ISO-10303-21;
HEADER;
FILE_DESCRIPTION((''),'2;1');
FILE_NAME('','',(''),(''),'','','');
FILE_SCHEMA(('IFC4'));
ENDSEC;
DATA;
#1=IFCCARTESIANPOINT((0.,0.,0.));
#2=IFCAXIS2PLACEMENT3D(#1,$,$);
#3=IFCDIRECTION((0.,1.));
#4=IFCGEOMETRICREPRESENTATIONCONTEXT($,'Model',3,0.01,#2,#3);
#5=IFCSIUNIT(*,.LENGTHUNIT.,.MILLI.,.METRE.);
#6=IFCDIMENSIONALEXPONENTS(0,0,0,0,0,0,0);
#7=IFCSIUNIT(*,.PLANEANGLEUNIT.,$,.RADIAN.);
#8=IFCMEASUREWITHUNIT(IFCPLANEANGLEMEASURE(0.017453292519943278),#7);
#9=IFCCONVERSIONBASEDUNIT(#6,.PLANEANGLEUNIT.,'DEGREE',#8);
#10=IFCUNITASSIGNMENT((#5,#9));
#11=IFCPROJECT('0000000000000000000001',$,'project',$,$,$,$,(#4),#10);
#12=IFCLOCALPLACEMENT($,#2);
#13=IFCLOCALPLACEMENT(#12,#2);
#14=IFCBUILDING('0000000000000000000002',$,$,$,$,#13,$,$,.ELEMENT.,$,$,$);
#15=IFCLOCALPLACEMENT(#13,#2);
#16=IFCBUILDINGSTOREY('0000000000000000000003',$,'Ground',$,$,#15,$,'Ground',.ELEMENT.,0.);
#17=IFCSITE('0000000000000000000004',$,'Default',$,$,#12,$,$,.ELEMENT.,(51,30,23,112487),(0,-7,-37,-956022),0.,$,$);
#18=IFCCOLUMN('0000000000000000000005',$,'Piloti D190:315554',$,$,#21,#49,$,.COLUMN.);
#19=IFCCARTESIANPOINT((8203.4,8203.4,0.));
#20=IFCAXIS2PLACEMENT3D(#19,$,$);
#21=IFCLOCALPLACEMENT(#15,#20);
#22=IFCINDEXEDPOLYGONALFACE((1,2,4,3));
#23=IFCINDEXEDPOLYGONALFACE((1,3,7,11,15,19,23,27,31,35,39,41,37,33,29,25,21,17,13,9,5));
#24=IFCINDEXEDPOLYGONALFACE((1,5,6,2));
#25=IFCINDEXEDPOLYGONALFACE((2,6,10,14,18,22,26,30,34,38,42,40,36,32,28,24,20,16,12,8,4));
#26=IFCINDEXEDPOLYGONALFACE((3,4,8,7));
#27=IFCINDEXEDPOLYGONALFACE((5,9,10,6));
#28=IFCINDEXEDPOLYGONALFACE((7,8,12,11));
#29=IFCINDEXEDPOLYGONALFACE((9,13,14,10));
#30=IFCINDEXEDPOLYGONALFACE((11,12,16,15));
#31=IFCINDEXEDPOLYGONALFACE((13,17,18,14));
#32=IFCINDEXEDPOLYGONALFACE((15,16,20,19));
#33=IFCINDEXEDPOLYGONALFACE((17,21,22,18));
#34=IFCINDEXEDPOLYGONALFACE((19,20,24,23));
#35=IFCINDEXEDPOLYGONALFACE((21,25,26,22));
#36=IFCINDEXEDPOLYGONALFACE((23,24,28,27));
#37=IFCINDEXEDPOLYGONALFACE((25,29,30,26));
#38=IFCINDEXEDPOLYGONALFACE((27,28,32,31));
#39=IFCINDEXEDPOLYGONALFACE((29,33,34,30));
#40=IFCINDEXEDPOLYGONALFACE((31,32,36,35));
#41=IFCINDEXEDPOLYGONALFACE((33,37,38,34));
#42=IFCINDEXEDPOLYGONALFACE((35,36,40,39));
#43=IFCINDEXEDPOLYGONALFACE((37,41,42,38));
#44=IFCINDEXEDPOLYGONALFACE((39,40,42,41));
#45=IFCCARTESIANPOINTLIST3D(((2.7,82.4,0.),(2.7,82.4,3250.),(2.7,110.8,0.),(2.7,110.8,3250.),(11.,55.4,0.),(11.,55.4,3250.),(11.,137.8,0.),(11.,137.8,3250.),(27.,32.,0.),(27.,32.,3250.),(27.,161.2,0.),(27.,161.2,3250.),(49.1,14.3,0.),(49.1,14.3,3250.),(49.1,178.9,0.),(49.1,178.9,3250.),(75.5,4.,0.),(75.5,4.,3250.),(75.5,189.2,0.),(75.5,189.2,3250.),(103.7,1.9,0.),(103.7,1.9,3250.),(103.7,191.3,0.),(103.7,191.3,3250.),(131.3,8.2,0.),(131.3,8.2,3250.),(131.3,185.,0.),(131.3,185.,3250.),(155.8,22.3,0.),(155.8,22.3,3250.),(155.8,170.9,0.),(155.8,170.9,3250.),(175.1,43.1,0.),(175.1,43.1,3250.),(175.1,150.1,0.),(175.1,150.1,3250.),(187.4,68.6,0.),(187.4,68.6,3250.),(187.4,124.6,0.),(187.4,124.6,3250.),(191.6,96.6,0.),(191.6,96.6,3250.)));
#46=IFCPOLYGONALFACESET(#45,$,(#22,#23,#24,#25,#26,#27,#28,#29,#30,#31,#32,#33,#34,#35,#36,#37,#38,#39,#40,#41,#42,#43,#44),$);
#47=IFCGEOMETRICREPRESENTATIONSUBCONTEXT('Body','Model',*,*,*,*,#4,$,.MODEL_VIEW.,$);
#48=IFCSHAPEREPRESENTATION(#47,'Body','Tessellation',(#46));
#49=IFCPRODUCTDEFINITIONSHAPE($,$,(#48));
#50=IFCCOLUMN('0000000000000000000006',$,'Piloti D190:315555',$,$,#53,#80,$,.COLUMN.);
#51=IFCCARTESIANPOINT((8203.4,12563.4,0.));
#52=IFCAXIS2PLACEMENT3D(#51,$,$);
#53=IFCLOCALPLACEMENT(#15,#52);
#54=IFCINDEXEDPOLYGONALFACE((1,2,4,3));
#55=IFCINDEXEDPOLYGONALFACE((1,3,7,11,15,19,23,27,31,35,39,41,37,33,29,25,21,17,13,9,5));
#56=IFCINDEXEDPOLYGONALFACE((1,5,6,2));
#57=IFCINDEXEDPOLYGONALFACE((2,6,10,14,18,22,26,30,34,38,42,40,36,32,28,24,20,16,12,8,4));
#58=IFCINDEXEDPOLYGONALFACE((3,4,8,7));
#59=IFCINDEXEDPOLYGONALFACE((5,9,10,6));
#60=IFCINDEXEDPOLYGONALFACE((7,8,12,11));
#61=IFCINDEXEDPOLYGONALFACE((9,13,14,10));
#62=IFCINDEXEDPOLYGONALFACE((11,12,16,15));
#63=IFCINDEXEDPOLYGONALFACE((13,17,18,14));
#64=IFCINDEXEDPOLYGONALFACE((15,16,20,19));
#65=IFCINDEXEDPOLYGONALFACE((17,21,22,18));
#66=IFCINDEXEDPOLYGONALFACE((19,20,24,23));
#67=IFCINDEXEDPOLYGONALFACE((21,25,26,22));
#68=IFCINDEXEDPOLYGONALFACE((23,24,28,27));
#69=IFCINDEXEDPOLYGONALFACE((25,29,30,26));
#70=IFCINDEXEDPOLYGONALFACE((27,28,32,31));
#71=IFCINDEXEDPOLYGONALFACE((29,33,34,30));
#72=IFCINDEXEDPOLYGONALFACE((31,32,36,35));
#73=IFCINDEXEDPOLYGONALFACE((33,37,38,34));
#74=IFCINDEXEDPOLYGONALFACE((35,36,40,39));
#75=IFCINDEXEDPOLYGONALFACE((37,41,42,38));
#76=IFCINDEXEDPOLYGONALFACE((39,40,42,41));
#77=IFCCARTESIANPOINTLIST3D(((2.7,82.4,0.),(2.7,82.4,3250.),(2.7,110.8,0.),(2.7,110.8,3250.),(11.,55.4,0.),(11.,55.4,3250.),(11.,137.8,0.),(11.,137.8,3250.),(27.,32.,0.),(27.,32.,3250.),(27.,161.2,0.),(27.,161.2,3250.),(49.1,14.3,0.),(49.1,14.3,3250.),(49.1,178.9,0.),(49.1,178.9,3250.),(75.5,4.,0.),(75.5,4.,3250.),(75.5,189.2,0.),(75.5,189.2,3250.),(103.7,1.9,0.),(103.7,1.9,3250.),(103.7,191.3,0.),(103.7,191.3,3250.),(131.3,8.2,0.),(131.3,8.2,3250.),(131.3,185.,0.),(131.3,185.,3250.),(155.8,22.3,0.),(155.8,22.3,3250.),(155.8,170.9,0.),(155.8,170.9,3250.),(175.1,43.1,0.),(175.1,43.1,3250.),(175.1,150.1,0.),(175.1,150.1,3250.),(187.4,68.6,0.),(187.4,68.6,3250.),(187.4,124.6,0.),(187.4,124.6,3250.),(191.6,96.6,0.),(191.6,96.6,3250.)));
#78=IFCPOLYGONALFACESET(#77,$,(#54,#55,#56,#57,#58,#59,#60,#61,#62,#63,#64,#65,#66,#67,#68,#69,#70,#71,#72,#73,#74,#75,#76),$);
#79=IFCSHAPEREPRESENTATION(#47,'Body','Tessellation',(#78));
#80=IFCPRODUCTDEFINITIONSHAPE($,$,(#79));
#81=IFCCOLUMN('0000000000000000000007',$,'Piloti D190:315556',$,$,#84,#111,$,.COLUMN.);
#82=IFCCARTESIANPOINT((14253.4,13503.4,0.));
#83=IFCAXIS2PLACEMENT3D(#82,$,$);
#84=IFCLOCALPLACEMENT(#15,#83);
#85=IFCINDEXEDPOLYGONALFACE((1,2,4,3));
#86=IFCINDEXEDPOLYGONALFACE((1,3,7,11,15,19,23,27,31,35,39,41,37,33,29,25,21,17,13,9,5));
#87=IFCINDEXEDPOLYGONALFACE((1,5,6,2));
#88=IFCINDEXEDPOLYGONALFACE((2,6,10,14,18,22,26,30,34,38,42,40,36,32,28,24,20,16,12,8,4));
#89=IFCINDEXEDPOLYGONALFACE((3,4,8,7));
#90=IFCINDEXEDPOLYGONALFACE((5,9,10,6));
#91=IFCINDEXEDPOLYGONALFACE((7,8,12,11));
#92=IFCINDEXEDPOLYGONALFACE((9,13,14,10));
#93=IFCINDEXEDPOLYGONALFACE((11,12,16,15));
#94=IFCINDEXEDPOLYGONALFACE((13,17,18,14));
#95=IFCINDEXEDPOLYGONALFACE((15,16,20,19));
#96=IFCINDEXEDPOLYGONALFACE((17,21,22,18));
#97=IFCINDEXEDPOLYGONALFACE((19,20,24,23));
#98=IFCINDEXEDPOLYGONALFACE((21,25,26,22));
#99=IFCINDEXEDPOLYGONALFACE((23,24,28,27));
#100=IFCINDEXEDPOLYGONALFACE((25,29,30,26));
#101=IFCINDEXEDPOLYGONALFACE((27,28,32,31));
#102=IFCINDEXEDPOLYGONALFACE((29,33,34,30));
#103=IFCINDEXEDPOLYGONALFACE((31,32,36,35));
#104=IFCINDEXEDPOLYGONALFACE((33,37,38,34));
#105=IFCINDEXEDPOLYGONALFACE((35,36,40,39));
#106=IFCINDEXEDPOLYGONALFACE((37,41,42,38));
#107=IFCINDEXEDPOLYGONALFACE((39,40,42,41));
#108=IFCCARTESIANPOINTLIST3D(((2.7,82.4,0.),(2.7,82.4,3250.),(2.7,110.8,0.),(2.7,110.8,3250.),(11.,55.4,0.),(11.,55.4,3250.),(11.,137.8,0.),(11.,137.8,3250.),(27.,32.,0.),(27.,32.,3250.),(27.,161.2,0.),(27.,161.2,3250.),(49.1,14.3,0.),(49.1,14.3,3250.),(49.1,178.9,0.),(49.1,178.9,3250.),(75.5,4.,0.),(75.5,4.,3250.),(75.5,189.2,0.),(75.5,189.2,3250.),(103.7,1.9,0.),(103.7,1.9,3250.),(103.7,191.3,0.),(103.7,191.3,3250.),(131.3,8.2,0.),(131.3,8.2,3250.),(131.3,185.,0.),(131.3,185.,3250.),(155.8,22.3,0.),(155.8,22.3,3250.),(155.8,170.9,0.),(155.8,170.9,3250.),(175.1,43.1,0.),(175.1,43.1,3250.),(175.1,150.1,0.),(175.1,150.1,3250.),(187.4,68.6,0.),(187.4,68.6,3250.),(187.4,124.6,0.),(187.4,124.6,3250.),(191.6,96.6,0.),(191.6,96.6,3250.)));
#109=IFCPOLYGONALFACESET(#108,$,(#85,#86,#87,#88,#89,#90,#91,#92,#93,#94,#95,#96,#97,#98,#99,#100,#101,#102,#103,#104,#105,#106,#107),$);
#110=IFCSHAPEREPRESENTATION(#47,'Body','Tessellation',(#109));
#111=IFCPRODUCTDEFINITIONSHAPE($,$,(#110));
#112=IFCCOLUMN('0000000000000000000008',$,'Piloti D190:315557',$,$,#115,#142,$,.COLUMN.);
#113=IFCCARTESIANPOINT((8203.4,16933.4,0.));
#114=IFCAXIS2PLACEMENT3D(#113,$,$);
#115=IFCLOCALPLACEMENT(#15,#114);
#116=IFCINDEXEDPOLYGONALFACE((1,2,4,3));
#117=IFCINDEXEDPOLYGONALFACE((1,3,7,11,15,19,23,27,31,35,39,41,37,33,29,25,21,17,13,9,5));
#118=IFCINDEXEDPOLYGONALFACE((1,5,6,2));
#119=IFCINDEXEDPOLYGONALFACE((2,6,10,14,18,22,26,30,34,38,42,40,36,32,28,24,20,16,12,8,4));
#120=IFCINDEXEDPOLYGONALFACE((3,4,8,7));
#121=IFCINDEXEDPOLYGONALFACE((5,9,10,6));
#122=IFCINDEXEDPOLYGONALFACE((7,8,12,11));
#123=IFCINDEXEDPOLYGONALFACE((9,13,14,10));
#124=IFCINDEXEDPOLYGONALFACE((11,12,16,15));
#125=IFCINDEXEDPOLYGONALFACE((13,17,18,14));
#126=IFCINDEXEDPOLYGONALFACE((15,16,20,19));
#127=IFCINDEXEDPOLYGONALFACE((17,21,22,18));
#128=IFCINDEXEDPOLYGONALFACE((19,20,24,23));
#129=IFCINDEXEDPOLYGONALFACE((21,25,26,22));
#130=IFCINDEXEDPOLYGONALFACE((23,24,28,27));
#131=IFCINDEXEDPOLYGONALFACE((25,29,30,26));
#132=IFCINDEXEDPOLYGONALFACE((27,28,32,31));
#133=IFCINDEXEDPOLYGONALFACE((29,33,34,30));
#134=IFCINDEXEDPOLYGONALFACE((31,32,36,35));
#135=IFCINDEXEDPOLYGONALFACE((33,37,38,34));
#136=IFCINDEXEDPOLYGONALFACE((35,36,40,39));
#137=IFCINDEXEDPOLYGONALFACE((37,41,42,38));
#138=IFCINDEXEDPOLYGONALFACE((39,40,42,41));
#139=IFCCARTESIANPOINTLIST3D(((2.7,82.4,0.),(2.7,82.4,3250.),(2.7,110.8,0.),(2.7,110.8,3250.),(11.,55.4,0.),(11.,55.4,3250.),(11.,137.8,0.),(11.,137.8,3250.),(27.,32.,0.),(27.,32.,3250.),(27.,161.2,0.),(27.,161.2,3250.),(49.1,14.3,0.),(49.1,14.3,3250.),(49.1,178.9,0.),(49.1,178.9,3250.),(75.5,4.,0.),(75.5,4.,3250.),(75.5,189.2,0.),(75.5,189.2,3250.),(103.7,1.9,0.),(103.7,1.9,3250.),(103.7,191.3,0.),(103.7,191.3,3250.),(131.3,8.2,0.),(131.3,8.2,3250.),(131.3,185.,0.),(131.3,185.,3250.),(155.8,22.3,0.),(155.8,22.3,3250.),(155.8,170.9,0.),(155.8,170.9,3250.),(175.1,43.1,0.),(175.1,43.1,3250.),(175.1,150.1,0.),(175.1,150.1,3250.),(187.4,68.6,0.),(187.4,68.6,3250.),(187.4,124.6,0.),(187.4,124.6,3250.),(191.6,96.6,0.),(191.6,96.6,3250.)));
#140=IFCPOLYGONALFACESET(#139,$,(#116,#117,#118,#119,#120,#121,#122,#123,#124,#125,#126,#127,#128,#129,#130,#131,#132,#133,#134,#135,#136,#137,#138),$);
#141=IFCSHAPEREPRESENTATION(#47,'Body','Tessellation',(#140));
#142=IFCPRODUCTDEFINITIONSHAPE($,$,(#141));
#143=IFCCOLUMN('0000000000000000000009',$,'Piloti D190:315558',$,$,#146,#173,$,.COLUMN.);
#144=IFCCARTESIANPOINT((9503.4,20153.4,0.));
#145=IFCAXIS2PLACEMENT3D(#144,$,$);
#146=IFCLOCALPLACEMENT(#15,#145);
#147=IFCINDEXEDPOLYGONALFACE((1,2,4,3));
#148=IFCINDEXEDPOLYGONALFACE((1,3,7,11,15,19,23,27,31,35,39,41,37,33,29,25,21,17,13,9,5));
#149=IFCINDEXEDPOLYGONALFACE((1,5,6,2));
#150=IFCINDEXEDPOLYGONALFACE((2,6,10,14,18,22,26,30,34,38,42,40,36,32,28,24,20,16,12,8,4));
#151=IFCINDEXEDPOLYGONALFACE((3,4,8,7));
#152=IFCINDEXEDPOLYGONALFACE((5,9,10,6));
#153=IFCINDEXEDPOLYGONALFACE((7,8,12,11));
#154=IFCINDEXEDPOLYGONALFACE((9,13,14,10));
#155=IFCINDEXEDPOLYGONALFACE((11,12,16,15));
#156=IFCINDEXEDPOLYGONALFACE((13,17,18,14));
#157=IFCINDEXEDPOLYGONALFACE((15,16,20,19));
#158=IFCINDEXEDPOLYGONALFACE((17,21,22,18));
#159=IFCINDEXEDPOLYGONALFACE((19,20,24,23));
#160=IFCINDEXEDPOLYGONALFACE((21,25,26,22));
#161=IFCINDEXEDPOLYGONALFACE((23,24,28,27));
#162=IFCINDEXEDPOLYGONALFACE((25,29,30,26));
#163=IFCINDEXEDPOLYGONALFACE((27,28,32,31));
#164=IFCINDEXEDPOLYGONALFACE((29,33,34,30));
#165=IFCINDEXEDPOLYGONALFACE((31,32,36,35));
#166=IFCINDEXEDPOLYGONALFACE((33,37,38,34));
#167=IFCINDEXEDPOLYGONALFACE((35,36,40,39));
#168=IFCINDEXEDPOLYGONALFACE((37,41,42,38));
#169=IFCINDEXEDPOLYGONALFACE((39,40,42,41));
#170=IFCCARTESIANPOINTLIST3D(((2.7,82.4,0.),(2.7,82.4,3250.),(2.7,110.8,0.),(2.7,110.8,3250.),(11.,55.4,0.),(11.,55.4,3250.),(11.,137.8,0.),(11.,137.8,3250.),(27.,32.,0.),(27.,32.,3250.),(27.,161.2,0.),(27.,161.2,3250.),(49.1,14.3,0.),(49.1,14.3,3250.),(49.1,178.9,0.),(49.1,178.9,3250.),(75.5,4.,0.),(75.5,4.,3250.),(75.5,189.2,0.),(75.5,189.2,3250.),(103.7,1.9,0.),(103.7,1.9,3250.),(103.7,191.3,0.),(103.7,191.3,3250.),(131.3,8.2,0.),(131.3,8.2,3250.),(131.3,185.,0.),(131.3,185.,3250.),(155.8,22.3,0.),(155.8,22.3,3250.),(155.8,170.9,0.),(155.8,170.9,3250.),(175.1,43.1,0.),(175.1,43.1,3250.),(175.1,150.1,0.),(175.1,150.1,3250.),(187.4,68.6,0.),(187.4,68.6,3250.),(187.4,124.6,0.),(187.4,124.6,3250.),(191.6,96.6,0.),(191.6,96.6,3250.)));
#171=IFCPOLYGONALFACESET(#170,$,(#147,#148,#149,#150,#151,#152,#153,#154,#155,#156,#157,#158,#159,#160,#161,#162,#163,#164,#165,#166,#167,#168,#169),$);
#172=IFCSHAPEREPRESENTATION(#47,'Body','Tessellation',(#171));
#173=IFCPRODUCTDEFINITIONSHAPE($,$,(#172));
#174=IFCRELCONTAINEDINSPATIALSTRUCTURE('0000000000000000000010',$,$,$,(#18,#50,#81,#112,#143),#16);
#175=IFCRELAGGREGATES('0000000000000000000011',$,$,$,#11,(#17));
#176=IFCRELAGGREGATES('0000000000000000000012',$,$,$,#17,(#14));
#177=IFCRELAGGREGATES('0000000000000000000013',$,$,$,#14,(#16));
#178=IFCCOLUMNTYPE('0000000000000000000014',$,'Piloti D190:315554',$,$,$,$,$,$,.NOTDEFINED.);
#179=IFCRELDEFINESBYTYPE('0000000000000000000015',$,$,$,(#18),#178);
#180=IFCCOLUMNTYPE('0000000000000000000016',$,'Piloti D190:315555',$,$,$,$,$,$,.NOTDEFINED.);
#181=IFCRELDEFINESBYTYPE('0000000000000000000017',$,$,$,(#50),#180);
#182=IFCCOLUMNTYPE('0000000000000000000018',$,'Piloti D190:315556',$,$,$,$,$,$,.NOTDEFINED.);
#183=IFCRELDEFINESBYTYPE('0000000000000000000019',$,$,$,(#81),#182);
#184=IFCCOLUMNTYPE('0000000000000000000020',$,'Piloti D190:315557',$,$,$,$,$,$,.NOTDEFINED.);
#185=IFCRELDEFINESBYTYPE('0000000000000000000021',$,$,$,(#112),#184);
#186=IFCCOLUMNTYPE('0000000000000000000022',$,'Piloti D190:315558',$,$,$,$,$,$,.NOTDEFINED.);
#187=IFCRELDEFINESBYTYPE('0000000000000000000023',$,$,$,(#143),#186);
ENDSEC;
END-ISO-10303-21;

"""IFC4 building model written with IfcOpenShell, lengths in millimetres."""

from ifc_helpers import new_model, entity, si_unit, converted_unit, direction, frame, origin, origin_2d_with_axis, place, context, subcontext, project, spatial, circle, extrude, type_object, element, save


model = new_model("IFC4")

# Units and contexts
model_context = context("Model", 3, precision=0.01, world=origin(), true_north=direction((0.0, 1.0)))
body_context = subcontext(model_context, "Body", "Model", "MODEL_VIEW")
ifc_project = project(units=[si_unit("LENGTHUNIT", "METRE", prefix="MILLI"), converted_unit("PLANEANGLEUNIT", "DEGREE", entity("IfcPlaneAngleMeasure", 0.017453292519943278), si_unit("PLANEANGLEUNIT", "RADIAN"), dimensions=[0, 0, 0, 0, 0, 0, 0])], contexts=[model_context])

# Site, building, storey
site_placement = place(None, origin())
site = spatial("IfcSite", under=ifc_project, at=site_placement, Name="Default", CompositionType="ELEMENT", RefLatitude=(51, 30, 23, 112487), RefLongitude=(0, -7, -37, -956022), RefElevation=0.0)
building_placement = place(site_placement, origin())
building = spatial("IfcBuilding", under=site, at=building_placement, CompositionType="ELEMENT")
storey_placement = place(building_placement, origin())
storey = spatial("IfcBuildingStorey", under=building, at=storey_placement, Name="Ground", LongName="Ground", CompositionType="ELEMENT", Elevation=0.0)

# Columns
column_type_1 = type_object("IfcColumnType", Name="Piloti D190:315554", PredefinedType="NOTDEFINED")
column_1_placement = place(storey_placement, frame((8203.4, 8203.4, 0.0)))
element("IfcColumn", 1, at=column_1_placement, inside=storey, type_object=column_type_1, Name="Piloti D190:315554", PredefinedType="COLUMN", context=body_context, shape_type="SweptSolid", body=[
    extrude(circle(Radius=95.0, at=origin_2d_with_axis()), frame((96.6, 96.6, 0.0)), (0.0, 0.0, 1.0), 3250.0),
])
column_type_2 = type_object("IfcColumnType", Name="Piloti D190:315555", PredefinedType="NOTDEFINED")
column_2_placement = place(storey_placement, frame((8203.4, 12563.4, 0.0)))
element("IfcColumn", 2, at=column_2_placement, inside=storey, type_object=column_type_2, Name="Piloti D190:315555", PredefinedType="COLUMN", context=body_context, shape_type="SweptSolid", body=[
    extrude(circle(Radius=95.0, at=origin_2d_with_axis()), frame((96.6, 96.6, 0.0)), (0.0, 0.0, 1.0), 3250.0),
])
column_type_3 = type_object("IfcColumnType", Name="Piloti D190:315556", PredefinedType="NOTDEFINED")
column_3_placement = place(storey_placement, frame((14253.4, 13503.4, 0.0)))
element("IfcColumn", 3, at=column_3_placement, inside=storey, type_object=column_type_3, Name="Piloti D190:315556", PredefinedType="COLUMN", context=body_context, shape_type="SweptSolid", body=[
    extrude(circle(Radius=95.0, at=origin_2d_with_axis()), frame((96.6, 96.6, 0.0)), (0.0, 0.0, 1.0), 3250.0),
])
column_type_4 = type_object("IfcColumnType", Name="Piloti D190:315557", PredefinedType="NOTDEFINED")
column_4_placement = place(storey_placement, frame((8203.4, 16933.4, 0.0)))
element("IfcColumn", 4, at=column_4_placement, inside=storey, type_object=column_type_4, Name="Piloti D190:315557", PredefinedType="COLUMN", context=body_context, shape_type="SweptSolid", body=[
    extrude(circle(Radius=95.0, at=origin_2d_with_axis()), frame((96.6, 96.6, 0.0)), (0.0, 0.0, 1.0), 3250.0),
])
column_type_5 = type_object("IfcColumnType", Name="Piloti D190:315558", PredefinedType="NOTDEFINED")
column_5_placement = place(storey_placement, frame((9503.4, 20153.4, 0.0)))
element("IfcColumn", 5, at=column_5_placement, inside=storey, type_object=column_type_5, Name="Piloti D190:315558", PredefinedType="COLUMN", context=body_context, shape_type="SweptSolid", body=[
    extrude(circle(Radius=95.0, at=origin_2d_with_axis()), frame((96.6, 96.6, 0.0)), (0.0, 0.0, 1.0), 3250.0),
])

save(model, "model.ifc")
